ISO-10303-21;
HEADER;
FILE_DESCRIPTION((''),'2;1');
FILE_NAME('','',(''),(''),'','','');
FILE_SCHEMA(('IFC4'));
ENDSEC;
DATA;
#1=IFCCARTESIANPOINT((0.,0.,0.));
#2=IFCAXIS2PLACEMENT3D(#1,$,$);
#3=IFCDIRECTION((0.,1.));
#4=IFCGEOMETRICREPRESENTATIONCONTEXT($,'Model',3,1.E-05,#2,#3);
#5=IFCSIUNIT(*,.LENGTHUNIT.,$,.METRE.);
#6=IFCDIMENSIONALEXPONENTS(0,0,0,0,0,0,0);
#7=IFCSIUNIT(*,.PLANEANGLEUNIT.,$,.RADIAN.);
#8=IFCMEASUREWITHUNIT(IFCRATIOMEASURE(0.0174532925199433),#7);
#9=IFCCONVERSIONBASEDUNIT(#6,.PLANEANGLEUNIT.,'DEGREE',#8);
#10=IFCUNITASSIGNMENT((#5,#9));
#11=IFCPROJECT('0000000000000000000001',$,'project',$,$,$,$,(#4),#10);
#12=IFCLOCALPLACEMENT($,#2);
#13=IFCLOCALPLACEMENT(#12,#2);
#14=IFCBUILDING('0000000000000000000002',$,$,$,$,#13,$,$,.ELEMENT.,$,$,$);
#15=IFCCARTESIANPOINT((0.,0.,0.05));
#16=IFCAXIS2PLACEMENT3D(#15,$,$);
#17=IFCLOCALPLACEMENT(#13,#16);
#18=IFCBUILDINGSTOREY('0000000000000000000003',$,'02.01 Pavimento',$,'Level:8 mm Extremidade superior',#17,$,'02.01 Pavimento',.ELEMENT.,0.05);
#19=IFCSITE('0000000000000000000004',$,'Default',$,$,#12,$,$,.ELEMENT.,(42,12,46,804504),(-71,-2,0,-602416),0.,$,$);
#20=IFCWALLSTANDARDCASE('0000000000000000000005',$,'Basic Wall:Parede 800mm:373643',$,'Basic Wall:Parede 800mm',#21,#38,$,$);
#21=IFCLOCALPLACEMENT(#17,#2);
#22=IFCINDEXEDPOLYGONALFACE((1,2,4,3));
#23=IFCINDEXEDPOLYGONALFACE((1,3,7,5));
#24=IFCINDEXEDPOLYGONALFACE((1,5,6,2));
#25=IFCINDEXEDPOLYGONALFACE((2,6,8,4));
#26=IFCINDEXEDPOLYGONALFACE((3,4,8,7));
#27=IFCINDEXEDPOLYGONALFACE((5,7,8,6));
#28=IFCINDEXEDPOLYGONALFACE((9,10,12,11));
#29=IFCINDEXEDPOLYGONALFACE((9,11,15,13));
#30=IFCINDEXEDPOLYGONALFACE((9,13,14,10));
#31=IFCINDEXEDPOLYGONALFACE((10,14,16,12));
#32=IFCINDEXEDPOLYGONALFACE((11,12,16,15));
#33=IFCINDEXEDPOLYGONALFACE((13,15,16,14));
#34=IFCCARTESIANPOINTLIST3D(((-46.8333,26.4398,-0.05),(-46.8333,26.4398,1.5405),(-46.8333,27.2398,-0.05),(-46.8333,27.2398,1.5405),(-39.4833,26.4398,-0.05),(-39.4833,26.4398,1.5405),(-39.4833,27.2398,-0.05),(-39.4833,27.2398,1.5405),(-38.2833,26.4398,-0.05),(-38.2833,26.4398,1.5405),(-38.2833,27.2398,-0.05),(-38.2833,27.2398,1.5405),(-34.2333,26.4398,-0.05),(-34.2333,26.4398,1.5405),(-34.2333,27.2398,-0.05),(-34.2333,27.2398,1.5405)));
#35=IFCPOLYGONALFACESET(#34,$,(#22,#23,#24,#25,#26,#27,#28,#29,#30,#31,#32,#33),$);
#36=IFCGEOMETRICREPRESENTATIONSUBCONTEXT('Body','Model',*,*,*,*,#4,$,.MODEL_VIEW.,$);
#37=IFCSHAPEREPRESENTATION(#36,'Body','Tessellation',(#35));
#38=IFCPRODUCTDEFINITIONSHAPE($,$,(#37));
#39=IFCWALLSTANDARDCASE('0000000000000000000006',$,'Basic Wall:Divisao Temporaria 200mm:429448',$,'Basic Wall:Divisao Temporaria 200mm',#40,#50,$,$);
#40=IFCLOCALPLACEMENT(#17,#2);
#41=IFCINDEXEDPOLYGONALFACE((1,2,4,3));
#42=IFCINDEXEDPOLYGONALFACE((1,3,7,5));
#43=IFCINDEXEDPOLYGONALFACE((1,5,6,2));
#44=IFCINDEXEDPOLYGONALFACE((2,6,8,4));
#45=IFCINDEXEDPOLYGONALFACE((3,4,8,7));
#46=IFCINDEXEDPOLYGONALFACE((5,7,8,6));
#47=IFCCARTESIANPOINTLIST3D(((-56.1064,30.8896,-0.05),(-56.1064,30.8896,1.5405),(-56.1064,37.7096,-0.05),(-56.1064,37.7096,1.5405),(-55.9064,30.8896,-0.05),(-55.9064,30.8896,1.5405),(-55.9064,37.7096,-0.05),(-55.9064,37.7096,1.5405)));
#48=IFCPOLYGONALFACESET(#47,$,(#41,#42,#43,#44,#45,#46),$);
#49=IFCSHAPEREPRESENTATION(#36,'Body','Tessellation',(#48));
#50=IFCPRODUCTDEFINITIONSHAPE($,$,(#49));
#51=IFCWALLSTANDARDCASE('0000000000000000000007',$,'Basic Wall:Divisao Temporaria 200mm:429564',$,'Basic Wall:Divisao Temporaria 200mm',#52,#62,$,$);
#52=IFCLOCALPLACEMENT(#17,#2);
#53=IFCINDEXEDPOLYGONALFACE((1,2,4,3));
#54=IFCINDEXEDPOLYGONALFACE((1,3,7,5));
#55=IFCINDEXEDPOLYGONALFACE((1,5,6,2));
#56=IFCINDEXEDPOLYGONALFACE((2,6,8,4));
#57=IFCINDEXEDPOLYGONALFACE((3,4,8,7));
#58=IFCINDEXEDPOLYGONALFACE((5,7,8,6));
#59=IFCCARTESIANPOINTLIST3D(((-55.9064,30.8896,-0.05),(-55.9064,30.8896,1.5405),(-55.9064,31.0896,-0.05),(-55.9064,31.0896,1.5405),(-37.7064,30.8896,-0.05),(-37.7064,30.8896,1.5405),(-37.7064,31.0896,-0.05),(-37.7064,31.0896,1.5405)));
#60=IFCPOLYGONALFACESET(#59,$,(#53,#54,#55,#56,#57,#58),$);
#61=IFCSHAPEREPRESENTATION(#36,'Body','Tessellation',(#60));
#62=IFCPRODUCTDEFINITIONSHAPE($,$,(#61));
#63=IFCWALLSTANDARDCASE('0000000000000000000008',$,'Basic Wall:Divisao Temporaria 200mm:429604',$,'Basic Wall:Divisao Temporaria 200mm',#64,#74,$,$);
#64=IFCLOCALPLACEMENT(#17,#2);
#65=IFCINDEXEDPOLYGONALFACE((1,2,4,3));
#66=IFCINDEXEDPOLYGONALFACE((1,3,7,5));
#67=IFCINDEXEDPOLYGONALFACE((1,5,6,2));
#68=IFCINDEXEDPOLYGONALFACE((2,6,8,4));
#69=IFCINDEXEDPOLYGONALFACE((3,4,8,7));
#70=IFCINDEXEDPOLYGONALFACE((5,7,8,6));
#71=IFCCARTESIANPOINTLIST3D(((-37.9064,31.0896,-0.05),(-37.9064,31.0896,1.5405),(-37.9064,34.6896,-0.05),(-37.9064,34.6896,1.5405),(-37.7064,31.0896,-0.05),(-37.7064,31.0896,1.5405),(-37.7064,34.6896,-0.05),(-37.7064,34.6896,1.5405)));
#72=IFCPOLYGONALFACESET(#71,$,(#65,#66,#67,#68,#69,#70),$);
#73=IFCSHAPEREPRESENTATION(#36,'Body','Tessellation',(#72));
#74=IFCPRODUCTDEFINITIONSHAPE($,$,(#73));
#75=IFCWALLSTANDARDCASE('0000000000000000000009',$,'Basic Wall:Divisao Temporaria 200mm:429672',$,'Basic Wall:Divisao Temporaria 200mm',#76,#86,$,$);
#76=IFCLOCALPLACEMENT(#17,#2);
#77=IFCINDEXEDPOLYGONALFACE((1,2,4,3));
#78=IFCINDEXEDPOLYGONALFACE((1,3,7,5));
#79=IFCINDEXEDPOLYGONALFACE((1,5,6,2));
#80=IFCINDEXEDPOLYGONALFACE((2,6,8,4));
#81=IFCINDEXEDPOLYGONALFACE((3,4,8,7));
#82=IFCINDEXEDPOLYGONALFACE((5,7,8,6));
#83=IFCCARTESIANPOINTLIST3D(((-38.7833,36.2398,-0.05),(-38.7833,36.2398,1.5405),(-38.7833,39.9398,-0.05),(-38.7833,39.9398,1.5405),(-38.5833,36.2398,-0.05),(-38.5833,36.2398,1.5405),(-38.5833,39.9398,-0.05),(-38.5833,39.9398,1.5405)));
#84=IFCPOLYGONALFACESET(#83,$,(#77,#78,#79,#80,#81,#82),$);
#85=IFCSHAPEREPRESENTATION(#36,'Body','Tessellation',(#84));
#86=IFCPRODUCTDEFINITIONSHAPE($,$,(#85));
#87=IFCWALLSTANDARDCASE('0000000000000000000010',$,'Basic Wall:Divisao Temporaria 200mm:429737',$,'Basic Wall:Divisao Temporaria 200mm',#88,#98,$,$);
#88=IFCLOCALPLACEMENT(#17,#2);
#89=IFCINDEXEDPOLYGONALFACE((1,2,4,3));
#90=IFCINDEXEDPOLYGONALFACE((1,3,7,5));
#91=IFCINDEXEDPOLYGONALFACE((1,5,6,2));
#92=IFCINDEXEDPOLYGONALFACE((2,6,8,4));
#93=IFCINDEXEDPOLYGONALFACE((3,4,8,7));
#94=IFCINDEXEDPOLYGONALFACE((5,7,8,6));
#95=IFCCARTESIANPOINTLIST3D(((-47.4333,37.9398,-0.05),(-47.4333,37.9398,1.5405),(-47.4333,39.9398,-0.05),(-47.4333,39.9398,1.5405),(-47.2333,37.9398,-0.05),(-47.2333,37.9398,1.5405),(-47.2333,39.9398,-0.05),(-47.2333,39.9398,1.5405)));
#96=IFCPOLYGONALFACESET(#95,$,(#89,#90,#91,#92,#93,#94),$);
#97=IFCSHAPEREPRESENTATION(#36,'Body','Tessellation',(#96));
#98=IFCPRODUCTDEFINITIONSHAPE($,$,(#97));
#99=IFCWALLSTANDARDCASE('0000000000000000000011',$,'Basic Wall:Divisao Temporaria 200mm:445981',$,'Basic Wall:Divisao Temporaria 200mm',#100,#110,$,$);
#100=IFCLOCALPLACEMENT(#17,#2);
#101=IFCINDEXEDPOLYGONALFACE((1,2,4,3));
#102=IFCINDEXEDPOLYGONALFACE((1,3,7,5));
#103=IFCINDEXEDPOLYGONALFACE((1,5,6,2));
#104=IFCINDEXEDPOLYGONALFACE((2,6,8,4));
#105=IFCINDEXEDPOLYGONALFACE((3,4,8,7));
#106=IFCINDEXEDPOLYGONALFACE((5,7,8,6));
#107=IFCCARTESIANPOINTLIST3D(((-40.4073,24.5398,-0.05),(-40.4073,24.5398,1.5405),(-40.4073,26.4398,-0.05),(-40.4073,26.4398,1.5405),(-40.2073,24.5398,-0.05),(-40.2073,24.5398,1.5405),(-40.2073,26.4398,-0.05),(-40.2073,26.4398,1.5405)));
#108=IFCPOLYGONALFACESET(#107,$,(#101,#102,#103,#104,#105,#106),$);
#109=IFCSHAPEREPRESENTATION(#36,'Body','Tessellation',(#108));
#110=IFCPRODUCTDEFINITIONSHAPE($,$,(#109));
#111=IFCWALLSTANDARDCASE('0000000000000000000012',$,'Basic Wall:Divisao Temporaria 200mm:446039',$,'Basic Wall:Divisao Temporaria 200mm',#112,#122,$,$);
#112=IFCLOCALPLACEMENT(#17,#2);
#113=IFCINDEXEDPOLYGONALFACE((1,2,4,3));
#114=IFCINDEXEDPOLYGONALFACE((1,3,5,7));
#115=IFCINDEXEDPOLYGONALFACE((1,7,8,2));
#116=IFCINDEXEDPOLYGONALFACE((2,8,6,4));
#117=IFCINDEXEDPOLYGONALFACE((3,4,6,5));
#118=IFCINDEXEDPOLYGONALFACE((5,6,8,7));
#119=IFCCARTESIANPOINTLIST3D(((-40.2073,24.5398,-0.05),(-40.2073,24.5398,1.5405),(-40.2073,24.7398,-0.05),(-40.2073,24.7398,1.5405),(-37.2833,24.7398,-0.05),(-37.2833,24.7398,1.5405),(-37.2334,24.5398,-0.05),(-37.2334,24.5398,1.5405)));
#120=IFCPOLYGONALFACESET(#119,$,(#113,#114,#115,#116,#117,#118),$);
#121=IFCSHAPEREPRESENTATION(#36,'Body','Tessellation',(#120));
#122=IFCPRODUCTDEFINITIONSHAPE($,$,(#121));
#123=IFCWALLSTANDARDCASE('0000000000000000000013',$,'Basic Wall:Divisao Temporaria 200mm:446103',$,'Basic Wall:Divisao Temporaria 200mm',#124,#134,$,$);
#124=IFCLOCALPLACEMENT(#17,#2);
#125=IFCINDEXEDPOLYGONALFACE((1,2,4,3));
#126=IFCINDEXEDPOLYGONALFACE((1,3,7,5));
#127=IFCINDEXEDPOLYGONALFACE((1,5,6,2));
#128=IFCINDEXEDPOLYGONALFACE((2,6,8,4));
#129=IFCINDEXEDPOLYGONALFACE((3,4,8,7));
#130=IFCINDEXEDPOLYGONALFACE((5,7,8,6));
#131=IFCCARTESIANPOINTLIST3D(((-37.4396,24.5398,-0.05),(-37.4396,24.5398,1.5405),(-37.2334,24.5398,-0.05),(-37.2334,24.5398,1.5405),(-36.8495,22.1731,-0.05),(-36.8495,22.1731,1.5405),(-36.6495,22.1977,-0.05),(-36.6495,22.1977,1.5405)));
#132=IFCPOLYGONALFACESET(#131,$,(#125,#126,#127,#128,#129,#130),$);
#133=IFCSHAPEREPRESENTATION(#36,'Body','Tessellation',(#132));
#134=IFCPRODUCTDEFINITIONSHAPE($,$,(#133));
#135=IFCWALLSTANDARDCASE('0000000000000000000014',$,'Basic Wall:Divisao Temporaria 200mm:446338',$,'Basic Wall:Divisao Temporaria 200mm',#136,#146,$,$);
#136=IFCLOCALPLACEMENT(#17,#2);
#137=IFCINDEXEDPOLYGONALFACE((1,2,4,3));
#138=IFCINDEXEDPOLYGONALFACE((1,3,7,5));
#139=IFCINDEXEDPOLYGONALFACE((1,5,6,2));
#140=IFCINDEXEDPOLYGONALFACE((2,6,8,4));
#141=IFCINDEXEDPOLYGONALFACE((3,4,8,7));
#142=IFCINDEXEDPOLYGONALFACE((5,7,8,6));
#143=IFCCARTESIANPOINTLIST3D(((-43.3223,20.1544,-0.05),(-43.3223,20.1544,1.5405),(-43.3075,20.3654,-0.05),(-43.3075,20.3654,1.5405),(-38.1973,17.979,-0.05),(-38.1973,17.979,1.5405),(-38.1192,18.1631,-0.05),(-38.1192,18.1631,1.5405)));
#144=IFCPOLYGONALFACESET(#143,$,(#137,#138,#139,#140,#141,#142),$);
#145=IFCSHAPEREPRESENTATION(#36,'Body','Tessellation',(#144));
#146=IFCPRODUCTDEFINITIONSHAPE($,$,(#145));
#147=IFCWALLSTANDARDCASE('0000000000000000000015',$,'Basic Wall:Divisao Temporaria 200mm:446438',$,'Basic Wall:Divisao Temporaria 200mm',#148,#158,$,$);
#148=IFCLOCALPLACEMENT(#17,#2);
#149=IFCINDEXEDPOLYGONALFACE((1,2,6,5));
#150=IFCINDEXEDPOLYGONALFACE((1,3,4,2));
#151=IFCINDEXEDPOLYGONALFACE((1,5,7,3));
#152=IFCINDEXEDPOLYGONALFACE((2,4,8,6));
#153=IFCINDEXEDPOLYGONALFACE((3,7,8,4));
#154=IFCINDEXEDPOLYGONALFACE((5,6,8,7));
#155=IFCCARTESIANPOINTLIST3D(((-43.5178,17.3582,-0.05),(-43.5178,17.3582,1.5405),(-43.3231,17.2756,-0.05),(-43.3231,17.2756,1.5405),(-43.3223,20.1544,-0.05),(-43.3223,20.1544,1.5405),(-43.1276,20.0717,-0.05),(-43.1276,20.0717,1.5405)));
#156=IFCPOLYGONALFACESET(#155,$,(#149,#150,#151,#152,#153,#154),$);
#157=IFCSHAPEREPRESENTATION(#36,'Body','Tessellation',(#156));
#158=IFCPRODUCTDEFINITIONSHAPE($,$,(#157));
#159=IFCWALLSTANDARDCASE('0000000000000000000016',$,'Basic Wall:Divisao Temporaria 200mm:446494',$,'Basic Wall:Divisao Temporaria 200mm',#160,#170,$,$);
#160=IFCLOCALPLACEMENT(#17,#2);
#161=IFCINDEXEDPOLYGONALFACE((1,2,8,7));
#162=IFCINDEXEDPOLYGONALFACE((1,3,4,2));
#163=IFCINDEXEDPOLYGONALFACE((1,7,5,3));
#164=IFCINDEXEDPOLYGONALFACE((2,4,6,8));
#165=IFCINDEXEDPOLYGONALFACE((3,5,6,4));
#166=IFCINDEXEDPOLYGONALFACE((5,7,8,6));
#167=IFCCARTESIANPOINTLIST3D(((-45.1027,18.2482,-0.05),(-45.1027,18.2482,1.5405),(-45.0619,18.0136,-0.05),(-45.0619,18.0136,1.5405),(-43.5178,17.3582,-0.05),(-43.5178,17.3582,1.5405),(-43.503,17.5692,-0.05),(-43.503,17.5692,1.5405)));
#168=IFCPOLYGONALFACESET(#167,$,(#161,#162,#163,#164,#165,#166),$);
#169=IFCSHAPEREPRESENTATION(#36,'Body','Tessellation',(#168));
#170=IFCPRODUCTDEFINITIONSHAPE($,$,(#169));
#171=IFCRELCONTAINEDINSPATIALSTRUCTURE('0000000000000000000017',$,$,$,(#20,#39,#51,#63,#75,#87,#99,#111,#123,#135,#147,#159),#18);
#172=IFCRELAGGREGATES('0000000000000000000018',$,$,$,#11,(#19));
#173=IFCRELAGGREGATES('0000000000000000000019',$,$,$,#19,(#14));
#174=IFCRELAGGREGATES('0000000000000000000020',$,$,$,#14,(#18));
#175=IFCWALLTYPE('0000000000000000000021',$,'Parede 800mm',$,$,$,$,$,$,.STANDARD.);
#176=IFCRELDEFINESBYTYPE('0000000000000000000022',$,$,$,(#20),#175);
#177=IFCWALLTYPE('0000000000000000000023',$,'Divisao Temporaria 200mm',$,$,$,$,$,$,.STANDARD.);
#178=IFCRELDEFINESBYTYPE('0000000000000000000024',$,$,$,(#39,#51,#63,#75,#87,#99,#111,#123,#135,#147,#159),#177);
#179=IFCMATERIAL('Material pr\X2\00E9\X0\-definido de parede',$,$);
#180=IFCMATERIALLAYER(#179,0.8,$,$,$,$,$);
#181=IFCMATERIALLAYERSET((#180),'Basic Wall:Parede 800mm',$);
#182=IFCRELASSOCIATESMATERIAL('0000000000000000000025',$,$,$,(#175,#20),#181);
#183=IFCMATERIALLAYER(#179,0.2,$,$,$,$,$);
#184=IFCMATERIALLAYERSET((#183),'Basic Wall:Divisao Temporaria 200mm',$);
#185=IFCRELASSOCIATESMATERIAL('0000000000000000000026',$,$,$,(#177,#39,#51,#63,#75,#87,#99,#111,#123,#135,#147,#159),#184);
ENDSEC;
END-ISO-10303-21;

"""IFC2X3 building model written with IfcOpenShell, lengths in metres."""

from ifc_helpers import new_model, entity, si_unit, converted_unit, direction, frame, frame_2d, origin, place, context, subcontext, project, spatial, polyline, rectangle, outline, extrude, clip, halfspace, material, layer, layer_set, layer_usage, type_object, element, save


model = new_model("IFC2X3")

# Units and contexts
model_context = context("Model", 3, precision=1e-05, world=origin(), true_north=direction((0.0, 1.0)))
body_context = subcontext(model_context, "Body", "Model", "MODEL_VIEW")
ifc_project = project(units=[si_unit("LENGTHUNIT", "METRE"), converted_unit("PLANEANGLEUNIT", "DEGREE", entity("IfcRatioMeasure", 0.0174532925199433), si_unit("PLANEANGLEUNIT", "RADIAN"), dimensions=[0, 0, 0, 0, 0, 0, 0])], contexts=[model_context])

# Site, building, storey
site_placement = place(None, origin())
site = spatial("IfcSite", under=ifc_project, at=site_placement, Name="Default", CompositionType="ELEMENT", RefLatitude=(42, 12, 46, 804504), RefLongitude=(-71, -2, 0, -602416), RefElevation=0.0)
building_placement = place(site_placement, origin())
building = spatial("IfcBuilding", under=site, at=building_placement, CompositionType="ELEMENT")
storey_placement = place(building_placement, frame((0.0, 0.0, 0.05)))
storey = spatial("IfcBuildingStorey", under=building, at=storey_placement, Name="02.01 Pavimento", ObjectType="Level:8 mm Extremidade superior", LongName="02.01 Pavimento", CompositionType="ELEMENT", Elevation=0.05)

# Shared definitions
ifc_material_1 = material(Name="Material pré-definido de parede")

# Wall, opening
ifc_layer_1 = layer(ifc_material_1, 0.8)
ifc_layer_set_1 = layer_set([ifc_layer_1], Name="Basic Wall:Parede 800mm")
ifc_layer_usage_1 = layer_usage(ifc_layer_set_1, "AXIS2", "POSITIVE", -0.4)
wall_type_1 = type_object("IfcWallType", Name="Parede 800mm", PredefinedType="STANDARD", material=ifc_layer_set_1)
wall_1_placement = place(storey_placement, frame((-46.8333, 26.8398, -0.05)))
wall_1 = element("IfcWallStandardCase", 1, at=wall_1_placement, inside=storey, type_object=wall_type_1, material=ifc_layer_usage_1, Name="Basic Wall:Parede 800mm:373643", ObjectType="Basic Wall:Parede 800mm", context=body_context, shape_type="Clipping", body=[
    clip(extrude(rectangle(XDim=12.6, YDim=0.8, at=frame_2d((6.3, 0.0), x_axis=(-1.0, 0.0))), origin(), (0.0, 0.0, 1.0), 1.5905), halfspace(frame((0.0, 0.0, -0.05)), True)),
])
opening_1_placement = place(wall_1_placement, frame((7.35, -1.924, 0.0)))
element("IfcOpeningElement", 2, at=opening_1_placement, cuts=wall_1, ObjectType="Opening", context=body_context, shape_type="SweptSolid", body=[
    extrude(rectangle(XDim=3.4, YDim=1.2, at=frame_2d((0.0, 0.0), x_axis=(1.0, 0.0))), frame((0.6, 0.0, 1.7), z_axis=(0.0, 1.0, 0.0), x_axis=(0.0, 0.0, 1.0)), (0.0, 0.0, 1.0), 3.048),
])

# Walls
ifc_layer_2 = layer(ifc_material_1, 0.2)
ifc_layer_set_2 = layer_set([ifc_layer_2], Name="Basic Wall:Divisao Temporaria 200mm")
ifc_layer_usage_2 = layer_usage(ifc_layer_set_2, "AXIS2", "POSITIVE", -0.1)
wall_type_2 = type_object("IfcWallType", Name="Divisao Temporaria 200mm", PredefinedType="STANDARD", material=ifc_layer_set_2)
wall_2_placement = place(storey_placement, frame((-56.0064, 37.7096, -0.05), z_axis=(0.0, 0.0, 1.0), x_axis=(0.0, -1.0, 0.0)))
element("IfcWallStandardCase", 3, at=wall_2_placement, inside=storey, type_object=wall_type_2, material=ifc_layer_usage_2, Name="Basic Wall:Divisao Temporaria 200mm:429448", ObjectType="Basic Wall:Divisao Temporaria 200mm", context=body_context, shape_type="Clipping", body=[
    clip(extrude(rectangle(XDim=6.82, YDim=0.2, at=frame_2d((3.41, 0.0), x_axis=(-1.0, 0.0))), origin(), (0.0, 0.0, 1.0), 1.5905), halfspace(frame((0.0, 0.0, -0.05)), True)),
])
ifc_layer_usage_3 = layer_usage(ifc_layer_set_2, "AXIS2", "POSITIVE", -0.1)
wall_3_placement = place(storey_placement, frame((-55.9064, 30.9896, -0.05)))
element("IfcWallStandardCase", 4, at=wall_3_placement, inside=storey, type_object=wall_type_2, material=ifc_layer_usage_3, Name="Basic Wall:Divisao Temporaria 200mm:429564", ObjectType="Basic Wall:Divisao Temporaria 200mm", context=body_context, shape_type="Clipping", body=[
    clip(extrude(rectangle(XDim=18.2, YDim=0.2, at=frame_2d((9.1, 0.0), x_axis=(-1.0, 0.0))), origin(), (0.0, 0.0, 1.0), 1.5905), halfspace(frame((0.0, 0.0, -0.05)), True)),
])
ifc_layer_usage_4 = layer_usage(ifc_layer_set_2, "AXIS2", "POSITIVE", -0.1)
wall_4_placement = place(storey_placement, frame((-37.8064, 31.0896, -0.05), z_axis=(0.0, 0.0, 1.0), x_axis=(0.0, 1.0, 0.0)))
element("IfcWallStandardCase", 5, at=wall_4_placement, inside=storey, type_object=wall_type_2, material=ifc_layer_usage_4, Name="Basic Wall:Divisao Temporaria 200mm:429604", ObjectType="Basic Wall:Divisao Temporaria 200mm", context=body_context, shape_type="Clipping", body=[
    clip(extrude(rectangle(XDim=3.6, YDim=0.2, at=frame_2d((1.8, 0.0), x_axis=(-1.0, 0.0))), origin(), (0.0, 0.0, 1.0), 1.5905), halfspace(frame((0.0, 0.0, -0.05)), True)),
])
ifc_layer_usage_5 = layer_usage(ifc_layer_set_2, "AXIS2", "NEGATIVE", 0.1)
wall_5_placement = place(storey_placement, frame((-38.6833, 39.9398, -0.05), z_axis=(0.0, 0.0, 1.0), x_axis=(0.0, -1.0, 0.0)))
element("IfcWallStandardCase", 6, at=wall_5_placement, inside=storey, type_object=wall_type_2, material=ifc_layer_usage_5, Name="Basic Wall:Divisao Temporaria 200mm:429672", ObjectType="Basic Wall:Divisao Temporaria 200mm", context=body_context, shape_type="Clipping", body=[
    clip(extrude(rectangle(XDim=3.7, YDim=0.2, at=frame_2d((1.85, 0.0), x_axis=(-1.0, 0.0))), origin(), (0.0, 0.0, 1.0), 1.5905), halfspace(frame((0.0, 0.0, -0.05)), True)),
])
ifc_layer_usage_6 = layer_usage(ifc_layer_set_2, "AXIS2", "POSITIVE", -0.1)
wall_6_placement = place(storey_placement, frame((-47.3333, 37.9398, -0.05), z_axis=(0.0, 0.0, 1.0), x_axis=(0.0, 1.0, 0.0)))
element("IfcWallStandardCase", 7, at=wall_6_placement, inside=storey, type_object=wall_type_2, material=ifc_layer_usage_6, Name="Basic Wall:Divisao Temporaria 200mm:429737", ObjectType="Basic Wall:Divisao Temporaria 200mm", context=body_context, shape_type="Clipping", body=[
    clip(extrude(rectangle(XDim=2.0, YDim=0.2, at=frame_2d((1.0, 0.0), x_axis=(-1.0, 0.0))), origin(), (0.0, 0.0, 1.0), 1.5905), halfspace(frame((0.0, 0.0, -0.05)), True)),
])
ifc_layer_usage_7 = layer_usage(ifc_layer_set_2, "AXIS2", "NEGATIVE", 0.1)
wall_7_placement = place(storey_placement, frame((-40.3073, 26.4398, -0.05), z_axis=(0.0, 0.0, 1.0), x_axis=(0.0, -1.0, 0.0)))
element("IfcWallStandardCase", 8, at=wall_7_placement, inside=storey, type_object=wall_type_2, material=ifc_layer_usage_7, Name="Basic Wall:Divisao Temporaria 200mm:445981", ObjectType="Basic Wall:Divisao Temporaria 200mm", context=body_context, shape_type="Clipping", body=[
    clip(extrude(rectangle(XDim=1.9, YDim=0.2, at=frame_2d((0.95, 0.0), x_axis=(-1.0, 0.0))), origin(), (0.0, 0.0, 1.0), 1.5905), halfspace(frame((0.0, 0.0, -0.05)), True)),
])
ifc_layer_usage_8 = layer_usage(ifc_layer_set_2, "AXIS2", "NEGATIVE", 0.1)
wall_8_placement = place(storey_placement, frame((-40.2073, 24.6398, -0.05)))
element("IfcWallStandardCase", 9, at=wall_8_placement, inside=storey, type_object=wall_type_2, material=ifc_layer_usage_8, Name="Basic Wall:Divisao Temporaria 200mm:446039", ObjectType="Basic Wall:Divisao Temporaria 200mm", context=body_context, shape_type="Clipping", body=[
    clip(extrude(outline(polyline([(2.9739, -0.1), (2.924, 0.1), (0.0, 0.1), (0.0, -0.1), (2.7677, -0.1), (2.9739, -0.1)])), origin(), (0.0, 0.0, 1.0), 1.5905), halfspace(frame((0.0, 0.0, -0.05)), True)),
])
ifc_layer_usage_9 = layer_usage(ifc_layer_set_2, "AXIS2", "NEGATIVE", 0.1)
wall_9_placement = place(storey_placement, frame((-37.3425, 24.564, -0.05), z_axis=(0.0, 0.0, 1.0), x_axis=(0.241922, -0.970296, 0.0)))
element("IfcWallStandardCase", 10, at=wall_9_placement, inside=storey, type_object=wall_type_2, material=ifc_layer_usage_9, Name="Basic Wall:Divisao Temporaria 200mm:446103", ObjectType="Basic Wall:Divisao Temporaria 200mm", context=body_context, shape_type="Clipping", body=[
    clip(extrude(outline(polyline([(2.4392, -0.1), (2.4637, 0.1), (0.0499, 0.1), (0.0, -0.1), (2.4392, -0.1)])), origin(), (0.0, 0.0, 1.0), 1.5905), halfspace(frame((0.0, 0.0, -0.05)), True)),
])
ifc_layer_usage_10 = layer_usage(ifc_layer_set_2, "AXIS2", "NEGATIVE", 0.1)
wall_10_placement = place(storey_placement, frame((-38.1583, 18.071, -0.05), z_axis=(0.0, 0.0, 1.0), x_axis=(-0.920505, 0.390731, 0.0)))
element("IfcWallStandardCase", 11, at=wall_10_placement, inside=storey, type_object=wall_type_2, material=ifc_layer_usage_10, Name="Basic Wall:Divisao Temporaria 200mm:446338", ObjectType="Basic Wall:Divisao Temporaria 200mm", context=body_context, shape_type="Clipping", body=[
    clip(extrude(outline(polyline([(5.6364, -0.1), (5.5675, 0.1), (5.356, 0.1), (0.0, 0.1), (0.0, -0.1), (5.6364, -0.1)])), origin(), (0.0, 0.0, 1.0), 1.5905), halfspace(frame((0.0, 0.0, -0.05)), True)),
])
ifc_layer_usage_11 = layer_usage(ifc_layer_set_2, "AXIS2", "NEGATIVE", 0.1)
wall_11_placement = place(storey_placement, frame((-43.2225, 20.1474, -0.05), z_axis=(0.0, 0.0, 1.0), x_axis=(-0.069756, -0.997564, 0.0)))
element("IfcWallStandardCase", 12, at=wall_11_placement, inside=storey, type_object=wall_type_2, material=ifc_layer_usage_11, Name="Basic Wall:Divisao Temporaria 200mm:446438", ObjectType="Basic Wall:Divisao Temporaria 200mm", context=body_context, shape_type="Clipping", body=[
    clip(extrude(outline(polyline([(2.803, -0.1), (2.8719, 0.1), (0.0689, 0.1), (0.0, -0.1), (2.5915, -0.1), (2.803, -0.1)])), origin(), (0.0, 0.0, 1.0), 1.5905), halfspace(frame((0.0, 0.0, -0.05)), True)),
])
ifc_layer_usage_12 = layer_usage(ifc_layer_set_2, "AXIS2", "NEGATIVE", 0.1)
wall_12_placement = place(storey_placement, frame((-43.4787, 17.4503, -0.05), z_axis=(0.0, 0.0, 1.0), x_axis=(-0.920505, 0.390731, 0.0)))
element("IfcWallStandardCase", 13, at=wall_12_placement, inside=storey, type_object=wall_type_2, material=ifc_layer_usage_12, Name="Basic Wall:Divisao Temporaria 200mm:446494", ObjectType="Basic Wall:Divisao Temporaria 200mm", context=body_context, shape_type="Clipping", body=[
    clip(extrude(outline(polyline([(1.8067, -0.1), (1.6775, 0.1), (0.0, 0.1), (0.0689, -0.1), (1.5686, -0.1), (1.8067, -0.1)])), origin(), (0.0, 0.0, 1.0), 1.5905), halfspace(frame((0.0, 0.0, -0.05)), True)),
])

save(model, "model.ifc")
